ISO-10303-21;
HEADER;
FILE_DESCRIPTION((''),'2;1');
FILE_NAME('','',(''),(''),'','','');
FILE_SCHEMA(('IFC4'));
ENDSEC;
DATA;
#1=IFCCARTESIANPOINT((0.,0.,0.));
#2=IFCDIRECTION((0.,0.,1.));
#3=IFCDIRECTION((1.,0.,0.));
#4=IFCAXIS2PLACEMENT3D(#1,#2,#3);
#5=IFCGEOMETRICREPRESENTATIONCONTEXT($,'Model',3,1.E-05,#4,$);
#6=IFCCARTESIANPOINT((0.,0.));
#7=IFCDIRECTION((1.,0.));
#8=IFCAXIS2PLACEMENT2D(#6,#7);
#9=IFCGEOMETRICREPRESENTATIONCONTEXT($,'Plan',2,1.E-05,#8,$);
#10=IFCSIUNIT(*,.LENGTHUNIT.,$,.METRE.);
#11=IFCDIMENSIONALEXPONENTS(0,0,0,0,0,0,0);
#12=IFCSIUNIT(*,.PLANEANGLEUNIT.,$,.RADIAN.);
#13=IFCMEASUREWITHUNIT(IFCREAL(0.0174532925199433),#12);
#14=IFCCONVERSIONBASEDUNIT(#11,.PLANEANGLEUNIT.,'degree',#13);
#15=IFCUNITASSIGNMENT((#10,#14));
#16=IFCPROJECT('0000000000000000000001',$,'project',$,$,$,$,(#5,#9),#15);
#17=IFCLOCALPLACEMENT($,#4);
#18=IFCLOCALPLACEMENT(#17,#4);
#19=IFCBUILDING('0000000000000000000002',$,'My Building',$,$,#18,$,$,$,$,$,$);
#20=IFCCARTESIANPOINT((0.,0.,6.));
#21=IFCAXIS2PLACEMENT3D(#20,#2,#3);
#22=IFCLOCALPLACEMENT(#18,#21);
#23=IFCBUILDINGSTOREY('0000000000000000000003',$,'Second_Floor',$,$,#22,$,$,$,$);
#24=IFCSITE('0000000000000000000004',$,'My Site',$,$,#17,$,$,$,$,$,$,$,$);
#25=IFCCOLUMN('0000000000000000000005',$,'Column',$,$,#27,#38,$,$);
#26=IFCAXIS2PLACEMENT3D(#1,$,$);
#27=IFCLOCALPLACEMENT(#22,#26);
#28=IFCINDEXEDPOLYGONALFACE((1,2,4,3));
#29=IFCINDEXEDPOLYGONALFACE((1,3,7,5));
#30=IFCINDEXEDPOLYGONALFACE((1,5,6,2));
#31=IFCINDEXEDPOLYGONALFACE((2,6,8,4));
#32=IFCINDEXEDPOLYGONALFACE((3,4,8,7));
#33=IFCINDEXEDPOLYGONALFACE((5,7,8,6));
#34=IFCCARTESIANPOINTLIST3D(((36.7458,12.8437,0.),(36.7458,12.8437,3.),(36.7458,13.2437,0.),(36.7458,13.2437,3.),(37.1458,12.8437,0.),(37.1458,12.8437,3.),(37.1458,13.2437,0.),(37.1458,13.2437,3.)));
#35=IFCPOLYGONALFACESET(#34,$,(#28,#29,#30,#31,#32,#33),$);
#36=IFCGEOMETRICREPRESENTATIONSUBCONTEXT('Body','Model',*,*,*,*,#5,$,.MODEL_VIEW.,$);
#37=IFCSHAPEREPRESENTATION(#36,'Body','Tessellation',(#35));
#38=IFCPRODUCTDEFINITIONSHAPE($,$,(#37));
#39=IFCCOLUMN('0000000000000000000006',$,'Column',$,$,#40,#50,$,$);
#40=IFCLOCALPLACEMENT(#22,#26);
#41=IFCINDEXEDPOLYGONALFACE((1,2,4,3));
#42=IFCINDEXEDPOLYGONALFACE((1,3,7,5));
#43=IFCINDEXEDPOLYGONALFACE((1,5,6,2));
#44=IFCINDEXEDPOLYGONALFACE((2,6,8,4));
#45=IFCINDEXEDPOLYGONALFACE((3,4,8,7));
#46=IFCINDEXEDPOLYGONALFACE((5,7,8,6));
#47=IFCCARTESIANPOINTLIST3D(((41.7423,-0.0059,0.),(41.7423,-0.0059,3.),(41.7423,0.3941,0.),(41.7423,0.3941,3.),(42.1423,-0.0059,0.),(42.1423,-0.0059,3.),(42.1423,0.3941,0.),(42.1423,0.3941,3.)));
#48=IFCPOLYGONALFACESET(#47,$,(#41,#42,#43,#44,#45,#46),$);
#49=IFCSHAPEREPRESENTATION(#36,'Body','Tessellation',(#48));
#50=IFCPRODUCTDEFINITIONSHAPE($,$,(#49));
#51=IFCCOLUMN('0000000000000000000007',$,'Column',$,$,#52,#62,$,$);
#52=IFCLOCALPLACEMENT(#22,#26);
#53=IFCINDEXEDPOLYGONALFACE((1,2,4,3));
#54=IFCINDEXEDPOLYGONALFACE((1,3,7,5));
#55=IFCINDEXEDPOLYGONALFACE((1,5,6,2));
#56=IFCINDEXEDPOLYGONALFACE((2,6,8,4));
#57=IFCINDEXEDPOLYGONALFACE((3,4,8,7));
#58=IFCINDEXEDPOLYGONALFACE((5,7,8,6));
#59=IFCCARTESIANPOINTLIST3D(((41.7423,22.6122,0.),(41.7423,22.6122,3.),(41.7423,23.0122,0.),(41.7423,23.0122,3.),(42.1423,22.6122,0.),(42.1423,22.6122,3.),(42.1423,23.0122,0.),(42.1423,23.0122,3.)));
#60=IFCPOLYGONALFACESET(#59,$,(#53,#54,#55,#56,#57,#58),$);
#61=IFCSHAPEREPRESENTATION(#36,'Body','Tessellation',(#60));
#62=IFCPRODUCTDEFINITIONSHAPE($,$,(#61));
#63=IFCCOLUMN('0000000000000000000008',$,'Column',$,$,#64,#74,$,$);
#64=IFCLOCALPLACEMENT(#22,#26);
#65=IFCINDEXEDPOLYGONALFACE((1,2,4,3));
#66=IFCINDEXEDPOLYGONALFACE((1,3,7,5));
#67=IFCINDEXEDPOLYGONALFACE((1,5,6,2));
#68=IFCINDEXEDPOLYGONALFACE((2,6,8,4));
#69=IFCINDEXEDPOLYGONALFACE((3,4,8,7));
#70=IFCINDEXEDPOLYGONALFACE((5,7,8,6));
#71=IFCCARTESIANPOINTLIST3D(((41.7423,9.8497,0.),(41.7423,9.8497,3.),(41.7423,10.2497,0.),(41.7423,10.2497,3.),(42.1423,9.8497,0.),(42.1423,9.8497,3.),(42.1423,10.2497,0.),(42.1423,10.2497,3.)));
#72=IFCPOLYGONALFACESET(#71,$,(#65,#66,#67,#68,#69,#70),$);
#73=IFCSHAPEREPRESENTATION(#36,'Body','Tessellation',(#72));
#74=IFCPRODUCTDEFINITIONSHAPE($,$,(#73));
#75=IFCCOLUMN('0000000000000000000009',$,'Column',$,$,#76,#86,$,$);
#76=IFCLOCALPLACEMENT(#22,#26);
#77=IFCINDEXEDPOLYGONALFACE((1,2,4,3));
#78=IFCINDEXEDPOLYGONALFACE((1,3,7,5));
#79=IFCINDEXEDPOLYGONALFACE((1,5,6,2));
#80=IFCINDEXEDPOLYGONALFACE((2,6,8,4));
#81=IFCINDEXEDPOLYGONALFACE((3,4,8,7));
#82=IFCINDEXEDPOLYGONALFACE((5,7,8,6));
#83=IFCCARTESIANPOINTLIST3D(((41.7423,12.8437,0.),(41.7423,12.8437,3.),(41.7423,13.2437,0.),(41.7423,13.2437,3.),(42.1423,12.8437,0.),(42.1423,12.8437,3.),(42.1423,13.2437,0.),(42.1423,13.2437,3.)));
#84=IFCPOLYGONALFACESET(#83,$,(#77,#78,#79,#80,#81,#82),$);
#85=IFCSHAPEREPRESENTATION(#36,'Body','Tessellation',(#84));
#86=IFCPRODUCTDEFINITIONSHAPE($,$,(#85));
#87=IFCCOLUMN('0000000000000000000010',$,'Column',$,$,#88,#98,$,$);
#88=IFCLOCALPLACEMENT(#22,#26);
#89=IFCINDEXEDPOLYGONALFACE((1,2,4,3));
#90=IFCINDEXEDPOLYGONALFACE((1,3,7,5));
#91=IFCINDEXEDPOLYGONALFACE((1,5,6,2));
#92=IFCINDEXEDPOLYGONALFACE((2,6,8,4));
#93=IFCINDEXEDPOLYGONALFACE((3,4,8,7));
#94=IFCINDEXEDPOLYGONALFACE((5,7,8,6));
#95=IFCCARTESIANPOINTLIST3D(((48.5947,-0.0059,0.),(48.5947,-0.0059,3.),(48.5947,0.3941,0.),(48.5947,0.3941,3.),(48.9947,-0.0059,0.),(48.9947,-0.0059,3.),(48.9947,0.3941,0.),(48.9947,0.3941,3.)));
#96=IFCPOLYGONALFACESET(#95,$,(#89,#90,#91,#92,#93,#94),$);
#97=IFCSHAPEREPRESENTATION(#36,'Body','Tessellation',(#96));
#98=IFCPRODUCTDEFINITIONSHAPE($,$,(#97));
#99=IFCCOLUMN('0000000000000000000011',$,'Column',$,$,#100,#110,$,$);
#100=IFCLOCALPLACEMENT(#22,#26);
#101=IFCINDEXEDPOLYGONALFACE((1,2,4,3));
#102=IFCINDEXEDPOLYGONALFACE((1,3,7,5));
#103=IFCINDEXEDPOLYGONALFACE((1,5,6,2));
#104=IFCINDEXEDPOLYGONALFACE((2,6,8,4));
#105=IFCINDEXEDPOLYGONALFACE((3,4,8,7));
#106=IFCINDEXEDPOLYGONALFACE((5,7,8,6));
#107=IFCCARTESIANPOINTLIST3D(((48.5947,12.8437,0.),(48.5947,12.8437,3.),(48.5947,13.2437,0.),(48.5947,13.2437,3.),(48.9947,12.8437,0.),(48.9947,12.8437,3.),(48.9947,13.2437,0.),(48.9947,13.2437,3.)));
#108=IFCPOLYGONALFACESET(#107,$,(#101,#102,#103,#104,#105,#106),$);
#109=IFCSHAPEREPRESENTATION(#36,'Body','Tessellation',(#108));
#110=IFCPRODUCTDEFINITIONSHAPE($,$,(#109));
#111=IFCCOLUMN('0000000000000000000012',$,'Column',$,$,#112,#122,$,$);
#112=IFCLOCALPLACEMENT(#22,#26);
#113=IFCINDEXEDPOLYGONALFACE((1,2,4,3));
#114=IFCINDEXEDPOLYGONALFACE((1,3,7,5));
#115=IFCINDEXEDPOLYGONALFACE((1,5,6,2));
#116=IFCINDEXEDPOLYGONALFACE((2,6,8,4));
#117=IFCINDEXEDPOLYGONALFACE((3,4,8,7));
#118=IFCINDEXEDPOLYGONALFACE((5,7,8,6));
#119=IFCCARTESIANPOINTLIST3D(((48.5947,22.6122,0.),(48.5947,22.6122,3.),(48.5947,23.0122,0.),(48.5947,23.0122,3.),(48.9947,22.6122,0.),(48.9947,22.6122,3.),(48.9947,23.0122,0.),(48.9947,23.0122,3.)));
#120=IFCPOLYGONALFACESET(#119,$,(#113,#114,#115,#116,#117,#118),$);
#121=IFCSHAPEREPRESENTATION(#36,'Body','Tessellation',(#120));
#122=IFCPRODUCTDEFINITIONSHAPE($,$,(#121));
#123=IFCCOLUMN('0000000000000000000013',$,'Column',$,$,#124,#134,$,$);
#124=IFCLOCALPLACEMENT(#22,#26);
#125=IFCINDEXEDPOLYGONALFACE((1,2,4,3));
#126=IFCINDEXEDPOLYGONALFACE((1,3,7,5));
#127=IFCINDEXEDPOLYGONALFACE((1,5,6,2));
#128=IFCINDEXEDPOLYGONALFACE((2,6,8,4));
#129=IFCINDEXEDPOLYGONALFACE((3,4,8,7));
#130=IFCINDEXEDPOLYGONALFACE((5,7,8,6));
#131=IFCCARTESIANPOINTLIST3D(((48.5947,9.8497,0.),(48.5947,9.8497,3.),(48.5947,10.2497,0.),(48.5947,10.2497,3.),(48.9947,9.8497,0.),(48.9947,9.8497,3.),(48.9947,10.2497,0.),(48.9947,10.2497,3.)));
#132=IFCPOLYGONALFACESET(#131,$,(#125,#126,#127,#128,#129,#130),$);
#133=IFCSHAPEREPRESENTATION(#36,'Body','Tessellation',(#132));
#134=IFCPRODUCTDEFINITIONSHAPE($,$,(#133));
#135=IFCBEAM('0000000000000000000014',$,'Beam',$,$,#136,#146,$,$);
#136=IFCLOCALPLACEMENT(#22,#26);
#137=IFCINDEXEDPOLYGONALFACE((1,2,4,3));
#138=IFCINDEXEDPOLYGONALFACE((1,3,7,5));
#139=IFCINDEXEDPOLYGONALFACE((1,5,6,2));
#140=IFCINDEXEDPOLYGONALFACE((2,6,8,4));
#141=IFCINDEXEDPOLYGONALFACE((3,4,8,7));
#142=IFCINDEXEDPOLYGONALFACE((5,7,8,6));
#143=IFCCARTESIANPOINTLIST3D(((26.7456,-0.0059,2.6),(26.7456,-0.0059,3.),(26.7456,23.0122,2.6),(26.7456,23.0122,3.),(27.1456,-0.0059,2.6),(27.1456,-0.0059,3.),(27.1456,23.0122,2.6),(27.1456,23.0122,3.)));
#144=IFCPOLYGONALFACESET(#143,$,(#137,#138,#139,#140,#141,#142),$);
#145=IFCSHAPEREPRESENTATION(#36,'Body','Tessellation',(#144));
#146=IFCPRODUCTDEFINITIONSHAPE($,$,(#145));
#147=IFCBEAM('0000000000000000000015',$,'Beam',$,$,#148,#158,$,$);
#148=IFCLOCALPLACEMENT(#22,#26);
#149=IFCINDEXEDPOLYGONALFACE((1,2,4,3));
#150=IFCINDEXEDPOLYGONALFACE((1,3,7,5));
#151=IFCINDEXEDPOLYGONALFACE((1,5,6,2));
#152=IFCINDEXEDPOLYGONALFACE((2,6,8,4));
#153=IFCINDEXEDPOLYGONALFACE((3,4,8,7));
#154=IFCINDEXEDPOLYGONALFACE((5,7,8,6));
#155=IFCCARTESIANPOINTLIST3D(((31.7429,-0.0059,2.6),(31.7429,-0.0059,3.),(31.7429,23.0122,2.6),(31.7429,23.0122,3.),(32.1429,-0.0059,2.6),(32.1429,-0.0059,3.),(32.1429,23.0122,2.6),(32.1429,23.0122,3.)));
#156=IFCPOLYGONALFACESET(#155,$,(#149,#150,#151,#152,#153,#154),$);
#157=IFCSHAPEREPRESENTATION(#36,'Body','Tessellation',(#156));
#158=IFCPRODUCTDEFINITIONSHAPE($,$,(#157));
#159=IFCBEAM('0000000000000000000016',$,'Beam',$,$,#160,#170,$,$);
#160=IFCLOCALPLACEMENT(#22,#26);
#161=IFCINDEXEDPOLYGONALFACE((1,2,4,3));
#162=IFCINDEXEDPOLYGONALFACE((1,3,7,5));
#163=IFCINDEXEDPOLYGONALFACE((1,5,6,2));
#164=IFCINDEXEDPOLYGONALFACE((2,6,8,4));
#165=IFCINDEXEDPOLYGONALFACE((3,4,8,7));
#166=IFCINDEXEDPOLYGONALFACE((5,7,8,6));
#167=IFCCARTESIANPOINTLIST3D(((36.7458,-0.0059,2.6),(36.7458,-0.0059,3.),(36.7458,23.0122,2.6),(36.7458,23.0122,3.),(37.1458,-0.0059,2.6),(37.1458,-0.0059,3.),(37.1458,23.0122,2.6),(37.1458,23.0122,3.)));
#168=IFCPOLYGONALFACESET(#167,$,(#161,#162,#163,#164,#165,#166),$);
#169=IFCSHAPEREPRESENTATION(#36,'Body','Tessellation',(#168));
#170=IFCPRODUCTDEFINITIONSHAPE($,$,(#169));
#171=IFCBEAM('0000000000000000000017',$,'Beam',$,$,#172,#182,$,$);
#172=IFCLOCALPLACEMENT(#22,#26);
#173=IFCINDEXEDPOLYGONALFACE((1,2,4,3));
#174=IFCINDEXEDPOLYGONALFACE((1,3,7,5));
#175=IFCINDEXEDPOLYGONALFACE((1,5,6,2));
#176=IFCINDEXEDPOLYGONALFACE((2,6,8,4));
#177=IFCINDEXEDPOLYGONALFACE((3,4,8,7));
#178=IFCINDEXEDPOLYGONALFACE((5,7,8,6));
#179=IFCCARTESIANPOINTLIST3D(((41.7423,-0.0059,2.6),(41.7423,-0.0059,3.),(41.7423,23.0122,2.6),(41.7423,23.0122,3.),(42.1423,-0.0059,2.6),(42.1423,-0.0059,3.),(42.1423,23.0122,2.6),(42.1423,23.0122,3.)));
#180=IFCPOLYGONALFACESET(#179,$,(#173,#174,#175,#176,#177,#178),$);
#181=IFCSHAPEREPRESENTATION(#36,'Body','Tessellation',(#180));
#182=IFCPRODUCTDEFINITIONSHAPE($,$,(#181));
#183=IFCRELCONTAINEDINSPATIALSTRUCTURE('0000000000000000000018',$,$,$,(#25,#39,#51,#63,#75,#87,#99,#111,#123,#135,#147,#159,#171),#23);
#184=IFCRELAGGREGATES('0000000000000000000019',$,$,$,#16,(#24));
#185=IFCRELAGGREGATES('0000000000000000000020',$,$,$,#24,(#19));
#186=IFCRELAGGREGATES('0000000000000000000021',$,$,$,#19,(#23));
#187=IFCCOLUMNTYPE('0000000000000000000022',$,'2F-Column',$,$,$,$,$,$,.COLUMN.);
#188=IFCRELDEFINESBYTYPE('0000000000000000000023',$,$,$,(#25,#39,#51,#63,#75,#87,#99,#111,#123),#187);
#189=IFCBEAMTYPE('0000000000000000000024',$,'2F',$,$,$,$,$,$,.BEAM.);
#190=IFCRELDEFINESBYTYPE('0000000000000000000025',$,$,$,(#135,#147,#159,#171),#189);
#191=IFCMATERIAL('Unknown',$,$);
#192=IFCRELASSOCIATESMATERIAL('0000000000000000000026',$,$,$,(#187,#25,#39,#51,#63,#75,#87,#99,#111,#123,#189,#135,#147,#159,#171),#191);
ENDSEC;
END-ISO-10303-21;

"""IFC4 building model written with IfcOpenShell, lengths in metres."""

from ifc_helpers import new_model, entity, si_unit, converted_unit, frame, origin_with_axes, origin_2d_with_axis, place, context, subcontext, project, spatial, rectangle, extrude, material, material_profile, profile_set, profile_usage, type_object, element, save


model = new_model("IFC4")

# Units and contexts
model_context = context("Model", 3, precision=1e-05, world=origin_with_axes())
plan_context = context("Plan", 2, precision=1e-05, world=origin_2d_with_axis())
body_context = subcontext(model_context, "Body", "Model", "MODEL_VIEW")
ifc_project = project(units=[si_unit("LENGTHUNIT", "METRE"), converted_unit("PLANEANGLEUNIT", "degree", entity("IfcReal", 0.0174532925199433), si_unit("PLANEANGLEUNIT", "RADIAN"), dimensions=[0, 0, 0, 0, 0, 0, 0])], contexts=[model_context, plan_context])

# Site, building, storey
site_placement = place(None, origin_with_axes())
site = spatial("IfcSite", under=ifc_project, at=site_placement, Name="My Site")
building_placement = place(site_placement, origin_with_axes())
building = spatial("IfcBuilding", under=site, at=building_placement, Name="My Building")
storey_placement = place(building_placement, frame((0.0, 0.0, 6.0), z_axis=(0.0, 0.0, 1.0), x_axis=(1.0, 0.0, 0.0)))
storey = spatial("IfcBuildingStorey", under=building, at=storey_placement, Name="Second_Floor")

# Columns
ifc_material = material(Name="Unknown")
ifc_material_profile_1 = material_profile(ifc_material, rectangle(XDim=0.4, YDim=0.4))
ifc_profile_set_1 = profile_set([ifc_material_profile_1])
column_type = type_object("IfcColumnType", Name="2F-Column", PredefinedType="COLUMN", material=ifc_profile_set_1)
ifc_profile_usage_1 = profile_usage(ifc_profile_set_1, cardinal=8)
column_1_placement = place(storey_placement, frame((36.9458, 13.2437, 0.0), z_axis=(0.0, 0.0, 1.0), x_axis=(1.0, 0.0, 0.0)))
element("IfcColumn", 1, at=column_1_placement, inside=storey, type_object=column_type, material=ifc_profile_usage_1, Name="Column", context=body_context, shape_type="SweptSolid", body=[
    extrude(rectangle(XDim=0.4, YDim=0.4), frame((0.0, -0.2, 0.0), z_axis=(0.0, 0.0, 1.0), x_axis=(1.0, 0.0, 0.0)), (0.0, 0.0, 1.0), 3.0),
])
ifc_profile_usage_2 = profile_usage(ifc_profile_set_1, cardinal=8)
column_2_placement = place(storey_placement, frame((41.9423, 0.3941, 0.0), z_axis=(0.0, 0.0, 1.0), x_axis=(1.0, 0.0, 0.0)))
element("IfcColumn", 2, at=column_2_placement, inside=storey, type_object=column_type, material=ifc_profile_usage_2, Name="Column", context=body_context, shape_type="SweptSolid", body=[
    extrude(rectangle(XDim=0.4, YDim=0.4), frame((0.0, -0.2, 0.0), z_axis=(0.0, 0.0, 1.0), x_axis=(1.0, 0.0, 0.0)), (0.0, 0.0, 1.0), 3.0),
])
ifc_profile_usage_3 = profile_usage(ifc_profile_set_1, cardinal=8)
column_3_placement = place(storey_placement, frame((41.9423, 23.0122, 0.0), z_axis=(0.0, 0.0, 1.0), x_axis=(1.0, 0.0, 0.0)))
element("IfcColumn", 3, at=column_3_placement, inside=storey, type_object=column_type, material=ifc_profile_usage_3, Name="Column", context=body_context, shape_type="SweptSolid", body=[
    extrude(rectangle(XDim=0.4, YDim=0.4), frame((0.0, -0.2, 0.0), z_axis=(0.0, 0.0, 1.0), x_axis=(1.0, 0.0, 0.0)), (0.0, 0.0, 1.0), 3.0),
])
ifc_profile_usage_4 = profile_usage(ifc_profile_set_1, cardinal=8)
column_4_placement = place(storey_placement, frame((41.9423, 10.2497, 0.0), z_axis=(0.0, 0.0, 1.0), x_axis=(1.0, 0.0, 0.0)))
element("IfcColumn", 4, at=column_4_placement, inside=storey, type_object=column_type, material=ifc_profile_usage_4, Name="Column", context=body_context, shape_type="SweptSolid", body=[
    extrude(rectangle(XDim=0.4, YDim=0.4), frame((0.0, -0.2, 0.0), z_axis=(0.0, 0.0, 1.0), x_axis=(1.0, 0.0, 0.0)), (0.0, 0.0, 1.0), 3.0),
])
ifc_profile_usage_5 = profile_usage(ifc_profile_set_1, cardinal=8)
column_5_placement = place(storey_placement, frame((41.9423, 13.2437, 0.0), z_axis=(0.0, 0.0, 1.0), x_axis=(1.0, 0.0, 0.0)))
element("IfcColumn", 5, at=column_5_placement, inside=storey, type_object=column_type, material=ifc_profile_usage_5, Name="Column", context=body_context, shape_type="SweptSolid", body=[
    extrude(rectangle(XDim=0.4, YDim=0.4), frame((0.0, -0.2, 0.0), z_axis=(0.0, 0.0, 1.0), x_axis=(1.0, 0.0, 0.0)), (0.0, 0.0, 1.0), 3.0),
])
ifc_profile_usage_6 = profile_usage(ifc_profile_set_1, cardinal=8)
column_6_placement = place(storey_placement, frame((48.7947, 0.3941, 0.0), z_axis=(0.0, 0.0, 1.0), x_axis=(1.0, 0.0, 0.0)))
element("IfcColumn", 6, at=column_6_placement, inside=storey, type_object=column_type, material=ifc_profile_usage_6, Name="Column", context=body_context, shape_type="SweptSolid", body=[
    extrude(rectangle(XDim=0.4, YDim=0.4), frame((0.0, -0.2, 0.0), z_axis=(0.0, 0.0, 1.0), x_axis=(1.0, 0.0, 0.0)), (0.0, 0.0, 1.0), 3.0),
])
ifc_profile_usage_7 = profile_usage(ifc_profile_set_1, cardinal=8)
column_7_placement = place(storey_placement, frame((48.7947, 13.2437, 0.0), z_axis=(0.0, 0.0, 1.0), x_axis=(1.0, 0.0, 0.0)))
element("IfcColumn", 7, at=column_7_placement, inside=storey, type_object=column_type, material=ifc_profile_usage_7, Name="Column", context=body_context, shape_type="SweptSolid", body=[
    extrude(rectangle(XDim=0.4, YDim=0.4), frame((0.0, -0.2, 0.0), z_axis=(0.0, 0.0, 1.0), x_axis=(1.0, 0.0, 0.0)), (0.0, 0.0, 1.0), 3.0),
])
ifc_profile_usage_8 = profile_usage(ifc_profile_set_1, cardinal=8)
column_8_placement = place(storey_placement, frame((48.7947, 23.0122, 0.0), z_axis=(0.0, 0.0, 1.0), x_axis=(1.0, 0.0, 0.0)))
element("IfcColumn", 8, at=column_8_placement, inside=storey, type_object=column_type, material=ifc_profile_usage_8, Name="Column", context=body_context, shape_type="SweptSolid", body=[
    extrude(rectangle(XDim=0.4, YDim=0.4), frame((0.0, -0.2, 0.0), z_axis=(0.0, 0.0, 1.0), x_axis=(1.0, 0.0, 0.0)), (0.0, 0.0, 1.0), 3.0),
])
ifc_profile_usage_9 = profile_usage(ifc_profile_set_1, cardinal=8)
column_9_placement = place(storey_placement, frame((48.7947, 10.2497, 0.0), z_axis=(0.0, 0.0, 1.0), x_axis=(1.0, 0.0, 0.0)))
element("IfcColumn", 9, at=column_9_placement, inside=storey, type_object=column_type, material=ifc_profile_usage_9, Name="Column", context=body_context, shape_type="SweptSolid", body=[
    extrude(rectangle(XDim=0.4, YDim=0.4), frame((0.0, -0.2, 0.0), z_axis=(0.0, 0.0, 1.0), x_axis=(1.0, 0.0, 0.0)), (0.0, 0.0, 1.0), 3.0),
])

# Beams
ifc_material_profile_2 = material_profile(ifc_material, rectangle(XDim=0.4, YDim=0.4))
ifc_profile_set_2 = profile_set([ifc_material_profile_2])
ifc_profile_usage_10 = profile_usage(ifc_profile_set_2, cardinal=8)
beam_type = type_object("IfcBeamType", Name="2F", PredefinedType="BEAM", material=ifc_profile_set_2)
beam_1_placement = place(storey_placement, frame((26.9456, -0.0059, 3.0), z_axis=(0.0, 1.0, 0.0), x_axis=(-1.0, 0.0, 0.0)))
element("IfcBeam", 10, at=beam_1_placement, inside=storey, type_object=beam_type, material=ifc_profile_usage_10, Name="Beam", context=body_context, shape_type="SweptSolid", body=[
    extrude(rectangle(XDim=0.4, YDim=0.4), frame((0.0, -0.2, 0.0), z_axis=(0.0, 0.0, 1.0), x_axis=(1.0, 0.0, 0.0)), (0.0, 0.0, 1.0), 23.0181),
])
ifc_profile_usage_11 = profile_usage(ifc_profile_set_2, cardinal=8)
beam_2_placement = place(storey_placement, frame((31.9429, -0.0059, 3.0), z_axis=(0.0, 1.0, 0.0), x_axis=(-1.0, 0.0, 0.0)))
element("IfcBeam", 11, at=beam_2_placement, inside=storey, type_object=beam_type, material=ifc_profile_usage_11, Name="Beam", context=body_context, shape_type="SweptSolid", body=[
    extrude(rectangle(XDim=0.4, YDim=0.4), frame((0.0, -0.2, 0.0), z_axis=(0.0, 0.0, 1.0), x_axis=(1.0, 0.0, 0.0)), (0.0, 0.0, 1.0), 23.0181),
])
ifc_profile_usage_12 = profile_usage(ifc_profile_set_2, cardinal=8)
beam_3_placement = place(storey_placement, frame((36.9458, -0.0059, 3.0), z_axis=(0.0, 1.0, 0.0), x_axis=(-1.0, 0.0, 0.0)))
element("IfcBeam", 12, at=beam_3_placement, inside=storey, type_object=beam_type, material=ifc_profile_usage_12, Name="Beam", context=body_context, shape_type="SweptSolid", body=[
    extrude(rectangle(XDim=0.4, YDim=0.4), frame((0.0, -0.2, 0.0), z_axis=(0.0, 0.0, 1.0), x_axis=(1.0, 0.0, 0.0)), (0.0, 0.0, 1.0), 23.0181),
])
ifc_profile_usage_13 = profile_usage(ifc_profile_set_2, cardinal=8)
beam_4_placement = place(storey_placement, frame((41.9423, -0.0059, 3.0), z_axis=(0.0, 1.0, 0.0), x_axis=(-1.0, 0.0, 0.0)))
element("IfcBeam", 13, at=beam_4_placement, inside=storey, type_object=beam_type, material=ifc_profile_usage_13, Name="Beam", context=body_context, shape_type="SweptSolid", body=[
    extrude(rectangle(XDim=0.4, YDim=0.4), frame((0.0, -0.2, 0.0), z_axis=(0.0, 0.0, 1.0), x_axis=(1.0, 0.0, 0.0)), (0.0, 0.0, 1.0), 23.0181),
])

save(model, "model.ifc")
